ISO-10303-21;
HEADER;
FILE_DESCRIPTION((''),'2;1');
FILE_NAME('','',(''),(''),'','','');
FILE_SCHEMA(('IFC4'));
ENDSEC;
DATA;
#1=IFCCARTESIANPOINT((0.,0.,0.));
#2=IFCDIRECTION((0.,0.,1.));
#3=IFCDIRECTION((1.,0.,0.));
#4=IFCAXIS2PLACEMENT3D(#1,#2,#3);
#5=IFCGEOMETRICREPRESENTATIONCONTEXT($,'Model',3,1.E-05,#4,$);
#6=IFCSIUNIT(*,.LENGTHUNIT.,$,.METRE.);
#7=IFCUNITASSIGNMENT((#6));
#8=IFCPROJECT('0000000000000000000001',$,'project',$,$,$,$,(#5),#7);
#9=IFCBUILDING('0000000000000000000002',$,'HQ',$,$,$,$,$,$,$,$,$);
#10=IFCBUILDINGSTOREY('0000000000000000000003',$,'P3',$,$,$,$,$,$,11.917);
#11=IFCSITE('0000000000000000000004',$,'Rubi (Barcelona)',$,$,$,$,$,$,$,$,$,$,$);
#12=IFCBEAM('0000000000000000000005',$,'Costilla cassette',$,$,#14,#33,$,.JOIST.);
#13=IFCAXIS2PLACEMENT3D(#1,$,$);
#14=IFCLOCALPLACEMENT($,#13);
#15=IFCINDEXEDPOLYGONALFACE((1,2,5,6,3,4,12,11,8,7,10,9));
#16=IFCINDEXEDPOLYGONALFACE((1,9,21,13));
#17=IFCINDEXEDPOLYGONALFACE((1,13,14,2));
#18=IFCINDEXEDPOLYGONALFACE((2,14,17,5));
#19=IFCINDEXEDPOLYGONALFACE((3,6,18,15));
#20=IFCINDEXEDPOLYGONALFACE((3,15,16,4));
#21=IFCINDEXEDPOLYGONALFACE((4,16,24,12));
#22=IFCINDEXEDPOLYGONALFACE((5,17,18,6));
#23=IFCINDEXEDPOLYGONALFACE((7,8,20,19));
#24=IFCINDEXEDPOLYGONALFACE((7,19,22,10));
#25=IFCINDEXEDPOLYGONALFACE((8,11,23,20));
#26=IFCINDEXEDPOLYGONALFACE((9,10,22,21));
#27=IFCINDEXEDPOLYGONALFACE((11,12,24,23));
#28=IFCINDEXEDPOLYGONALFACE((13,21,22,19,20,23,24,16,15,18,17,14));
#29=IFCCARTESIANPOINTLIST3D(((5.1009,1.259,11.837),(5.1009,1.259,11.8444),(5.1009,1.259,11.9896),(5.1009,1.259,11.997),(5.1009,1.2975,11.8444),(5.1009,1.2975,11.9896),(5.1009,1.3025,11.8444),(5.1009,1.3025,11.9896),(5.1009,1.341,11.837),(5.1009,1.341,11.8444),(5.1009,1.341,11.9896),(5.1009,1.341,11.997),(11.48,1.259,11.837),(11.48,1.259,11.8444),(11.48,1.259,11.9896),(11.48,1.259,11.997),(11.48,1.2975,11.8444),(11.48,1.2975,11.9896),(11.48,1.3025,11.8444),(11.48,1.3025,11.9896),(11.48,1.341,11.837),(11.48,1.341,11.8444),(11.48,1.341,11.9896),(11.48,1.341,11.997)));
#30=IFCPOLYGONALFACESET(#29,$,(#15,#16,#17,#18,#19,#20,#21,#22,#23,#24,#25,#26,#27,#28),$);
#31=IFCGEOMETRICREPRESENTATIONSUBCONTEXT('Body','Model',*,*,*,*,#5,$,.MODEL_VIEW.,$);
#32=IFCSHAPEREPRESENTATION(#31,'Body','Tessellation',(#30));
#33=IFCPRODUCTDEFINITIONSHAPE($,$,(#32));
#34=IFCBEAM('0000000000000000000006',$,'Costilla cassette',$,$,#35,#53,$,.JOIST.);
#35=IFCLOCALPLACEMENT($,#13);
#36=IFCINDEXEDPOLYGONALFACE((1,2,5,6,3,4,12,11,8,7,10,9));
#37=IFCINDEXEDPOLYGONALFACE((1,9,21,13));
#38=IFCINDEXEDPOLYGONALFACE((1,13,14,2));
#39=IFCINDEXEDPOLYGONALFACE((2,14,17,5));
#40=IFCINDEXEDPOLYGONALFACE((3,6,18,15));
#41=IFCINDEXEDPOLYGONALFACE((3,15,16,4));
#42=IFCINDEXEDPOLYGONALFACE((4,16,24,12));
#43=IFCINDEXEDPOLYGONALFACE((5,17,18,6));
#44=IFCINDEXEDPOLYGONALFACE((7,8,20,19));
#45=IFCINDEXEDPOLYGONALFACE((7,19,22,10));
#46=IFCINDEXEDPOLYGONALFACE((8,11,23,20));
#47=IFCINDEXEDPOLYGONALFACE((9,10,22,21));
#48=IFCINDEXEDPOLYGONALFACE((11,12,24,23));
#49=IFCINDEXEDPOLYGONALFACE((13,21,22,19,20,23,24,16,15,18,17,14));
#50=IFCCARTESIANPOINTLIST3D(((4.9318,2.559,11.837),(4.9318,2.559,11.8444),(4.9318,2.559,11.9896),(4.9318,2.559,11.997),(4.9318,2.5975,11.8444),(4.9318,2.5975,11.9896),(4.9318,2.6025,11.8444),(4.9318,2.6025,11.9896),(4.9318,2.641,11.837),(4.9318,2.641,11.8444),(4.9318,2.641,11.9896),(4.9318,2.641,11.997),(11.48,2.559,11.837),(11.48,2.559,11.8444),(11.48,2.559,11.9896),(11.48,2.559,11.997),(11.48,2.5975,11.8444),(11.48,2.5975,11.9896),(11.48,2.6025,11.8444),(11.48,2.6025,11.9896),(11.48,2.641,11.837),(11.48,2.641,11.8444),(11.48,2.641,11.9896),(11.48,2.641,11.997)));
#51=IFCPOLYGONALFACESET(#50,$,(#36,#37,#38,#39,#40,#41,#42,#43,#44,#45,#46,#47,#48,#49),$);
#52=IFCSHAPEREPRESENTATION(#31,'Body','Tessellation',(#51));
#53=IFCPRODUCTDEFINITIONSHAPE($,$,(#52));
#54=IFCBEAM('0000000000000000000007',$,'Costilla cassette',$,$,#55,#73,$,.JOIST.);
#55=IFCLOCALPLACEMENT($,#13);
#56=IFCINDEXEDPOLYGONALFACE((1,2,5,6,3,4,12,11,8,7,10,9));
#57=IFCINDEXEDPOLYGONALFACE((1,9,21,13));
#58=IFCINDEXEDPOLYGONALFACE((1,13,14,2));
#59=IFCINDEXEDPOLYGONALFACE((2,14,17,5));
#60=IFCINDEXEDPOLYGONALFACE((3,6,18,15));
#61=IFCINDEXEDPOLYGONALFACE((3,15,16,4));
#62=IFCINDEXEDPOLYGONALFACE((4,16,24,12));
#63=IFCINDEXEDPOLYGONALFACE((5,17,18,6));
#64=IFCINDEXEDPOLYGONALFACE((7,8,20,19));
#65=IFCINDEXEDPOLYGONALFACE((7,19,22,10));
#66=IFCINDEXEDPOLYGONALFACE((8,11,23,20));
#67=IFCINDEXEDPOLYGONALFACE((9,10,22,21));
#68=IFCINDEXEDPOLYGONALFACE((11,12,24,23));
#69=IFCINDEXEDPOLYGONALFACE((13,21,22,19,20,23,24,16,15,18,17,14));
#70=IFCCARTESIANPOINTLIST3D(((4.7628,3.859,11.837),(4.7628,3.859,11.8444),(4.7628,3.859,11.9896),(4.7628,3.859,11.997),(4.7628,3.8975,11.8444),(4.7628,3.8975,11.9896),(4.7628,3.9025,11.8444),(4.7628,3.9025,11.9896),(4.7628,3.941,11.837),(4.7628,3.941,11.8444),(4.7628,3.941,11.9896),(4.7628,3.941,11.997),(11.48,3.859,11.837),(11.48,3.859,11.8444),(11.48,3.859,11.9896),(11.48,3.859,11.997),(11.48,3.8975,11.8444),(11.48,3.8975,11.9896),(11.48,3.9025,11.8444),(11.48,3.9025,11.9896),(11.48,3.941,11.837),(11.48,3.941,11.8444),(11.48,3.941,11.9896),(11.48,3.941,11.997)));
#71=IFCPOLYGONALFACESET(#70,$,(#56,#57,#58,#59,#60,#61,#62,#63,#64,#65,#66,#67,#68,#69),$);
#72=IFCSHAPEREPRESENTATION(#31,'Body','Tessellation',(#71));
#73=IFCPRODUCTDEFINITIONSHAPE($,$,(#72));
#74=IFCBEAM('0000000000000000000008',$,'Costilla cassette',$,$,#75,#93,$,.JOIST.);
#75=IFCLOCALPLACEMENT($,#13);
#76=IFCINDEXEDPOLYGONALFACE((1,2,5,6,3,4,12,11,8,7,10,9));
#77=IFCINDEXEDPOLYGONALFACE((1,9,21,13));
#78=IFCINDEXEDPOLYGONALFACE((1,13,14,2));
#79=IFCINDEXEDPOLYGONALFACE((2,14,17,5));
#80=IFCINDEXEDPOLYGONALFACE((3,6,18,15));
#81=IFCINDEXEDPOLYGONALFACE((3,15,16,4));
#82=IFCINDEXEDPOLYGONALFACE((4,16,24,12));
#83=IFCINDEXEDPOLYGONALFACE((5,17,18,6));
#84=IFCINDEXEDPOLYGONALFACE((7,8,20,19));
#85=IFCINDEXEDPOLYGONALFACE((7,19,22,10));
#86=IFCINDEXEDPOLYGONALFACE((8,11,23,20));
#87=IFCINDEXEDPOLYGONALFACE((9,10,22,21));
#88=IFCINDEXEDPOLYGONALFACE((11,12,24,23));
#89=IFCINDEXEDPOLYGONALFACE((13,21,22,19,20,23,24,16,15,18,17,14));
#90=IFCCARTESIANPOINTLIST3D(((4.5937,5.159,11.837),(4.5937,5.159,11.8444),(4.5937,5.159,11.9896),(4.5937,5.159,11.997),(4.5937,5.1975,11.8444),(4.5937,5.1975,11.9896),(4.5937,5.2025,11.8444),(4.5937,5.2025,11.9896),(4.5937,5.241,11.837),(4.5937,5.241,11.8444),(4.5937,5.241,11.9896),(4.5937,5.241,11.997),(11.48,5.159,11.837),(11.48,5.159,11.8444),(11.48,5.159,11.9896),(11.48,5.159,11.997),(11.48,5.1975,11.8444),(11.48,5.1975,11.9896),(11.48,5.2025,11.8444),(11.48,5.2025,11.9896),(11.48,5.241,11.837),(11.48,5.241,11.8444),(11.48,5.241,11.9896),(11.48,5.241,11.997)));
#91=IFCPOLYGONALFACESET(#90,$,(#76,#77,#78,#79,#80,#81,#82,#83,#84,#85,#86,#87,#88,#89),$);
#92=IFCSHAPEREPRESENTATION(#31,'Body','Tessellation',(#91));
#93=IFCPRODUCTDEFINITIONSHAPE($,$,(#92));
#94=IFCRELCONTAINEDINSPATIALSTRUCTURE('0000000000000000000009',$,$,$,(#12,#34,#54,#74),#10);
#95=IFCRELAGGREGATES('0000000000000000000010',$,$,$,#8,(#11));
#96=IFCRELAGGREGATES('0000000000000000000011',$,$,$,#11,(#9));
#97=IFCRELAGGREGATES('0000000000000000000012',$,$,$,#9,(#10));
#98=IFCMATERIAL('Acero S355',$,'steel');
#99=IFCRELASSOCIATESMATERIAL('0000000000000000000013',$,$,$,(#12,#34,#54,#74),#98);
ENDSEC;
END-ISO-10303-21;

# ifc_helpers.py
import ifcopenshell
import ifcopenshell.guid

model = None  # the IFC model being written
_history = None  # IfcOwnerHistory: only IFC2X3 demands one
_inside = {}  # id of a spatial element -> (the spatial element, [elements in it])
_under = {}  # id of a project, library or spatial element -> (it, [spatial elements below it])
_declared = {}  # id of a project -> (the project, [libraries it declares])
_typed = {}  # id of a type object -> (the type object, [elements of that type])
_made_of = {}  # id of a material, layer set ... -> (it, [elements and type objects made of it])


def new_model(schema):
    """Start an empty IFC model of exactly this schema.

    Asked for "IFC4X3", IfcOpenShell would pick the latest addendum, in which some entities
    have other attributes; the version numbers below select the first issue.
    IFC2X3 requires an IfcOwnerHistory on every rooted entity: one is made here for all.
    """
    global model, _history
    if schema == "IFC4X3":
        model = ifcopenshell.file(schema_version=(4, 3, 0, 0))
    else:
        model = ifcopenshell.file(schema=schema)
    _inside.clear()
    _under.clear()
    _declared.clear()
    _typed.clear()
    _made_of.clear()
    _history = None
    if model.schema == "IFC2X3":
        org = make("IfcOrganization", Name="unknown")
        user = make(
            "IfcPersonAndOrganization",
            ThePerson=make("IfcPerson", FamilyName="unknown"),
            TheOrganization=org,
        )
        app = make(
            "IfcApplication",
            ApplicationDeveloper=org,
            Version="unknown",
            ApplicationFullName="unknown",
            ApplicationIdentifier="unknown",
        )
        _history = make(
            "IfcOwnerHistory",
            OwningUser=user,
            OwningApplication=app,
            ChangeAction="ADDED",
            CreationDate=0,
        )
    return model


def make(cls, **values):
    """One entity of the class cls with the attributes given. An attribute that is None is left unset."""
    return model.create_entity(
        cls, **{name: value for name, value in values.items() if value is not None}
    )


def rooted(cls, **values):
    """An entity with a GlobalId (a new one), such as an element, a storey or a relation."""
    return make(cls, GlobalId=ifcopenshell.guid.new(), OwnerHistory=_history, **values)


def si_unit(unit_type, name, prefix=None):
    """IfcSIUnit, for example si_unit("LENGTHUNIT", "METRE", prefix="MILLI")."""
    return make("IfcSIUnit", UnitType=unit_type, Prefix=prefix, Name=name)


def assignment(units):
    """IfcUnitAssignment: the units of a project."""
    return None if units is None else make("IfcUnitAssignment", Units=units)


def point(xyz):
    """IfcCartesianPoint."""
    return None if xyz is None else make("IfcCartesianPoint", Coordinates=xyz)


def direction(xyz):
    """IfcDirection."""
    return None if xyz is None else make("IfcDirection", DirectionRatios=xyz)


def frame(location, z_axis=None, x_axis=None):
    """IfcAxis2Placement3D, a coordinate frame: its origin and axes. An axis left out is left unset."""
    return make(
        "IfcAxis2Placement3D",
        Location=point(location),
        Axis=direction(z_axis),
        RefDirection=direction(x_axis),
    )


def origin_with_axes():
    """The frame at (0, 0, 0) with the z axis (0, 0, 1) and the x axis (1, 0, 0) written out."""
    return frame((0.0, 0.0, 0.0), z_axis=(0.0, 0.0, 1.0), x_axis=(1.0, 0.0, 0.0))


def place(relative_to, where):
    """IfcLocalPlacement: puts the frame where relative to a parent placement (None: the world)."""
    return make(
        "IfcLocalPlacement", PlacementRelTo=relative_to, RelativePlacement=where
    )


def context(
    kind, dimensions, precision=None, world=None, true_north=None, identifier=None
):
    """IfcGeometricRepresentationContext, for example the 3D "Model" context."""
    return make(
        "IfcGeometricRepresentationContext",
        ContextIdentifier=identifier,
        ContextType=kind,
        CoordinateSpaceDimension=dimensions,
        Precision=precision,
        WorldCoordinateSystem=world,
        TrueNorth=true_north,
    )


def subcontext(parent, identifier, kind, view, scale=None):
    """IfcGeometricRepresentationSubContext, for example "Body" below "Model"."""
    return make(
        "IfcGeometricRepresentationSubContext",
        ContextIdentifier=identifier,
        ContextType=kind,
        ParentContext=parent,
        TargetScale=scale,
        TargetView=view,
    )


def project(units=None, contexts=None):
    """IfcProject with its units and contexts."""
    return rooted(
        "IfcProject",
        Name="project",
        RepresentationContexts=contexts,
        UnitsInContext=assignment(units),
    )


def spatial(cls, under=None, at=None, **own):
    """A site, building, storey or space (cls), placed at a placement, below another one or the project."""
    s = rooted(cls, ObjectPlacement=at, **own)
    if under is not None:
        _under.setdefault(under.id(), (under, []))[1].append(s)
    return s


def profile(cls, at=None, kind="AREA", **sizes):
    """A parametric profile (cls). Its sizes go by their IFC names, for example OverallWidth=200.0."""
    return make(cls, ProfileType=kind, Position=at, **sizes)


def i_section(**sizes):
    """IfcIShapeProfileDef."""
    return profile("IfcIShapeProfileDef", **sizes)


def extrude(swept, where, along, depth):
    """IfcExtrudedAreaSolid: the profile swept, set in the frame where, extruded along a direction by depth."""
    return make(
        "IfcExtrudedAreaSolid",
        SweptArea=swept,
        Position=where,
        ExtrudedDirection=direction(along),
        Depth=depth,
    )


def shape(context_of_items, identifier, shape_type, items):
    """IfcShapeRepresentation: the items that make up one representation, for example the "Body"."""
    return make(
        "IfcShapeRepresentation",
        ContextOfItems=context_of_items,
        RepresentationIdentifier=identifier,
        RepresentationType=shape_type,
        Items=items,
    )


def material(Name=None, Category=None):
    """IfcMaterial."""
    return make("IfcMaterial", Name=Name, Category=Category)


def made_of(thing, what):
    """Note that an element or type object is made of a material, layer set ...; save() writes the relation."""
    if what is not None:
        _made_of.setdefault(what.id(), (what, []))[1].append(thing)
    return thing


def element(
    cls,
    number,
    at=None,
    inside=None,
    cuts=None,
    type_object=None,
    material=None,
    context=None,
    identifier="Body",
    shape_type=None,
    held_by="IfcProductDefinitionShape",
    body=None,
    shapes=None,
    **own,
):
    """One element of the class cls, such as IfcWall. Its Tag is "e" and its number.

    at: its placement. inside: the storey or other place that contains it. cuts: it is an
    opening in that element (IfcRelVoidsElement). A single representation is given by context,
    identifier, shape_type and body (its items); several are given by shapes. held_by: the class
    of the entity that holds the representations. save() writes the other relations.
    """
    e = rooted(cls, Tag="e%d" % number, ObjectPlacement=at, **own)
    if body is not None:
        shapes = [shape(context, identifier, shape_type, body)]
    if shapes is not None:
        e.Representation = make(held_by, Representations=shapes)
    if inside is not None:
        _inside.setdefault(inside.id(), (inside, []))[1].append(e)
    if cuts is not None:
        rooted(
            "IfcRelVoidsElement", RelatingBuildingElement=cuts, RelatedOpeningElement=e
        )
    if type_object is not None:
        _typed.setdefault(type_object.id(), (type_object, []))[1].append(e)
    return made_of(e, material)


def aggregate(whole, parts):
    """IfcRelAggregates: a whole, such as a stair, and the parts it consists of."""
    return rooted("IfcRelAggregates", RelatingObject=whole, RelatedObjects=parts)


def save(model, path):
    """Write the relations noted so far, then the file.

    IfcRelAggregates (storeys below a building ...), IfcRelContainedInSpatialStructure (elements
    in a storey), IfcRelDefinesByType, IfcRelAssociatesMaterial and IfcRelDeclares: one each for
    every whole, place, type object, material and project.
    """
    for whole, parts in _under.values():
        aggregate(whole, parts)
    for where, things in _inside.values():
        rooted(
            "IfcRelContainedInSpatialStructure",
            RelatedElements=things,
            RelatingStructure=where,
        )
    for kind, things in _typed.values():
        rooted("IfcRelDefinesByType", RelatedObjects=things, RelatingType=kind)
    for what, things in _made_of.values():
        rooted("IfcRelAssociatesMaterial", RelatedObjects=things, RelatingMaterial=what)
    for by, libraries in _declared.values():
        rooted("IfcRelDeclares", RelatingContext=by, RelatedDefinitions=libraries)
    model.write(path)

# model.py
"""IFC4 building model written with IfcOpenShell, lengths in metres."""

from ifc_helpers import new_model, si_unit, frame, origin_with_axes, place, context, subcontext, project, spatial, i_section, extrude, material, element, save


model = new_model("IFC4")

# Units and contexts
model_context = context("Model", 3, precision=1e-05, world=origin_with_axes())
body_context = subcontext(model_context, "Body", "Model", "MODEL_VIEW")
ifc_project = project(units=[si_unit("LENGTHUNIT", "METRE")], contexts=[model_context])

# Site, building, storey
site = spatial("IfcSite", under=ifc_project, Name="Rubi (Barcelona)")
building = spatial("IfcBuilding", under=site, Name="HQ")
storey = spatial("IfcBuildingStorey", under=building, Name="P3", Elevation=11.917)

# Shared definitions
ifc_material = material(Name="Acero S355", Category="steel")

# Beams
beam_1_placement = place(None, origin_with_axes())
element("IfcBeam", 1, at=beam_1_placement, inside=storey, material=ifc_material, Name="Costilla cassette", PredefinedType="JOIST", context=body_context, shape_type="SweptSolid", body=[
    extrude(i_section(OverallWidth=0.082, OverallDepth=0.16, WebThickness=0.005, FlangeThickness=0.0074), frame((5.1009, 1.3, 11.917), z_axis=(1.0, 0.0, 0.0), x_axis=(0.0, 1.0, 0.0)), (0.0, 0.0, 1.0), 6.3791),
])
beam_2_placement = place(None, origin_with_axes())
element("IfcBeam", 2, at=beam_2_placement, inside=storey, material=ifc_material, Name="Costilla cassette", PredefinedType="JOIST", context=body_context, shape_type="SweptSolid", body=[
    extrude(i_section(OverallWidth=0.082, OverallDepth=0.16, WebThickness=0.005, FlangeThickness=0.0074), frame((4.9318, 2.6, 11.917), z_axis=(1.0, 0.0, 0.0), x_axis=(0.0, 1.0, 0.0)), (0.0, 0.0, 1.0), 6.5482),
])
beam_3_placement = place(None, origin_with_axes())
element("IfcBeam", 3, at=beam_3_placement, inside=storey, material=ifc_material, Name="Costilla cassette", PredefinedType="JOIST", context=body_context, shape_type="SweptSolid", body=[
    extrude(i_section(OverallWidth=0.082, OverallDepth=0.16, WebThickness=0.005, FlangeThickness=0.0074), frame((4.7628, 3.9, 11.917), z_axis=(1.0, 0.0, 0.0), x_axis=(0.0, 1.0, 0.0)), (0.0, 0.0, 1.0), 6.7172),
])
beam_4_placement = place(None, origin_with_axes())
element("IfcBeam", 4, at=beam_4_placement, inside=storey, material=ifc_material, Name="Costilla cassette", PredefinedType="JOIST", context=body_context, shape_type="SweptSolid", body=[
    extrude(i_section(OverallWidth=0.082, OverallDepth=0.16, WebThickness=0.005, FlangeThickness=0.0074), frame((4.5937, 5.2, 11.917), z_axis=(1.0, 0.0, 0.0), x_axis=(0.0, 1.0, 0.0)), (0.0, 0.0, 1.0), 6.8863),
])

save(model, "model.ifc")
